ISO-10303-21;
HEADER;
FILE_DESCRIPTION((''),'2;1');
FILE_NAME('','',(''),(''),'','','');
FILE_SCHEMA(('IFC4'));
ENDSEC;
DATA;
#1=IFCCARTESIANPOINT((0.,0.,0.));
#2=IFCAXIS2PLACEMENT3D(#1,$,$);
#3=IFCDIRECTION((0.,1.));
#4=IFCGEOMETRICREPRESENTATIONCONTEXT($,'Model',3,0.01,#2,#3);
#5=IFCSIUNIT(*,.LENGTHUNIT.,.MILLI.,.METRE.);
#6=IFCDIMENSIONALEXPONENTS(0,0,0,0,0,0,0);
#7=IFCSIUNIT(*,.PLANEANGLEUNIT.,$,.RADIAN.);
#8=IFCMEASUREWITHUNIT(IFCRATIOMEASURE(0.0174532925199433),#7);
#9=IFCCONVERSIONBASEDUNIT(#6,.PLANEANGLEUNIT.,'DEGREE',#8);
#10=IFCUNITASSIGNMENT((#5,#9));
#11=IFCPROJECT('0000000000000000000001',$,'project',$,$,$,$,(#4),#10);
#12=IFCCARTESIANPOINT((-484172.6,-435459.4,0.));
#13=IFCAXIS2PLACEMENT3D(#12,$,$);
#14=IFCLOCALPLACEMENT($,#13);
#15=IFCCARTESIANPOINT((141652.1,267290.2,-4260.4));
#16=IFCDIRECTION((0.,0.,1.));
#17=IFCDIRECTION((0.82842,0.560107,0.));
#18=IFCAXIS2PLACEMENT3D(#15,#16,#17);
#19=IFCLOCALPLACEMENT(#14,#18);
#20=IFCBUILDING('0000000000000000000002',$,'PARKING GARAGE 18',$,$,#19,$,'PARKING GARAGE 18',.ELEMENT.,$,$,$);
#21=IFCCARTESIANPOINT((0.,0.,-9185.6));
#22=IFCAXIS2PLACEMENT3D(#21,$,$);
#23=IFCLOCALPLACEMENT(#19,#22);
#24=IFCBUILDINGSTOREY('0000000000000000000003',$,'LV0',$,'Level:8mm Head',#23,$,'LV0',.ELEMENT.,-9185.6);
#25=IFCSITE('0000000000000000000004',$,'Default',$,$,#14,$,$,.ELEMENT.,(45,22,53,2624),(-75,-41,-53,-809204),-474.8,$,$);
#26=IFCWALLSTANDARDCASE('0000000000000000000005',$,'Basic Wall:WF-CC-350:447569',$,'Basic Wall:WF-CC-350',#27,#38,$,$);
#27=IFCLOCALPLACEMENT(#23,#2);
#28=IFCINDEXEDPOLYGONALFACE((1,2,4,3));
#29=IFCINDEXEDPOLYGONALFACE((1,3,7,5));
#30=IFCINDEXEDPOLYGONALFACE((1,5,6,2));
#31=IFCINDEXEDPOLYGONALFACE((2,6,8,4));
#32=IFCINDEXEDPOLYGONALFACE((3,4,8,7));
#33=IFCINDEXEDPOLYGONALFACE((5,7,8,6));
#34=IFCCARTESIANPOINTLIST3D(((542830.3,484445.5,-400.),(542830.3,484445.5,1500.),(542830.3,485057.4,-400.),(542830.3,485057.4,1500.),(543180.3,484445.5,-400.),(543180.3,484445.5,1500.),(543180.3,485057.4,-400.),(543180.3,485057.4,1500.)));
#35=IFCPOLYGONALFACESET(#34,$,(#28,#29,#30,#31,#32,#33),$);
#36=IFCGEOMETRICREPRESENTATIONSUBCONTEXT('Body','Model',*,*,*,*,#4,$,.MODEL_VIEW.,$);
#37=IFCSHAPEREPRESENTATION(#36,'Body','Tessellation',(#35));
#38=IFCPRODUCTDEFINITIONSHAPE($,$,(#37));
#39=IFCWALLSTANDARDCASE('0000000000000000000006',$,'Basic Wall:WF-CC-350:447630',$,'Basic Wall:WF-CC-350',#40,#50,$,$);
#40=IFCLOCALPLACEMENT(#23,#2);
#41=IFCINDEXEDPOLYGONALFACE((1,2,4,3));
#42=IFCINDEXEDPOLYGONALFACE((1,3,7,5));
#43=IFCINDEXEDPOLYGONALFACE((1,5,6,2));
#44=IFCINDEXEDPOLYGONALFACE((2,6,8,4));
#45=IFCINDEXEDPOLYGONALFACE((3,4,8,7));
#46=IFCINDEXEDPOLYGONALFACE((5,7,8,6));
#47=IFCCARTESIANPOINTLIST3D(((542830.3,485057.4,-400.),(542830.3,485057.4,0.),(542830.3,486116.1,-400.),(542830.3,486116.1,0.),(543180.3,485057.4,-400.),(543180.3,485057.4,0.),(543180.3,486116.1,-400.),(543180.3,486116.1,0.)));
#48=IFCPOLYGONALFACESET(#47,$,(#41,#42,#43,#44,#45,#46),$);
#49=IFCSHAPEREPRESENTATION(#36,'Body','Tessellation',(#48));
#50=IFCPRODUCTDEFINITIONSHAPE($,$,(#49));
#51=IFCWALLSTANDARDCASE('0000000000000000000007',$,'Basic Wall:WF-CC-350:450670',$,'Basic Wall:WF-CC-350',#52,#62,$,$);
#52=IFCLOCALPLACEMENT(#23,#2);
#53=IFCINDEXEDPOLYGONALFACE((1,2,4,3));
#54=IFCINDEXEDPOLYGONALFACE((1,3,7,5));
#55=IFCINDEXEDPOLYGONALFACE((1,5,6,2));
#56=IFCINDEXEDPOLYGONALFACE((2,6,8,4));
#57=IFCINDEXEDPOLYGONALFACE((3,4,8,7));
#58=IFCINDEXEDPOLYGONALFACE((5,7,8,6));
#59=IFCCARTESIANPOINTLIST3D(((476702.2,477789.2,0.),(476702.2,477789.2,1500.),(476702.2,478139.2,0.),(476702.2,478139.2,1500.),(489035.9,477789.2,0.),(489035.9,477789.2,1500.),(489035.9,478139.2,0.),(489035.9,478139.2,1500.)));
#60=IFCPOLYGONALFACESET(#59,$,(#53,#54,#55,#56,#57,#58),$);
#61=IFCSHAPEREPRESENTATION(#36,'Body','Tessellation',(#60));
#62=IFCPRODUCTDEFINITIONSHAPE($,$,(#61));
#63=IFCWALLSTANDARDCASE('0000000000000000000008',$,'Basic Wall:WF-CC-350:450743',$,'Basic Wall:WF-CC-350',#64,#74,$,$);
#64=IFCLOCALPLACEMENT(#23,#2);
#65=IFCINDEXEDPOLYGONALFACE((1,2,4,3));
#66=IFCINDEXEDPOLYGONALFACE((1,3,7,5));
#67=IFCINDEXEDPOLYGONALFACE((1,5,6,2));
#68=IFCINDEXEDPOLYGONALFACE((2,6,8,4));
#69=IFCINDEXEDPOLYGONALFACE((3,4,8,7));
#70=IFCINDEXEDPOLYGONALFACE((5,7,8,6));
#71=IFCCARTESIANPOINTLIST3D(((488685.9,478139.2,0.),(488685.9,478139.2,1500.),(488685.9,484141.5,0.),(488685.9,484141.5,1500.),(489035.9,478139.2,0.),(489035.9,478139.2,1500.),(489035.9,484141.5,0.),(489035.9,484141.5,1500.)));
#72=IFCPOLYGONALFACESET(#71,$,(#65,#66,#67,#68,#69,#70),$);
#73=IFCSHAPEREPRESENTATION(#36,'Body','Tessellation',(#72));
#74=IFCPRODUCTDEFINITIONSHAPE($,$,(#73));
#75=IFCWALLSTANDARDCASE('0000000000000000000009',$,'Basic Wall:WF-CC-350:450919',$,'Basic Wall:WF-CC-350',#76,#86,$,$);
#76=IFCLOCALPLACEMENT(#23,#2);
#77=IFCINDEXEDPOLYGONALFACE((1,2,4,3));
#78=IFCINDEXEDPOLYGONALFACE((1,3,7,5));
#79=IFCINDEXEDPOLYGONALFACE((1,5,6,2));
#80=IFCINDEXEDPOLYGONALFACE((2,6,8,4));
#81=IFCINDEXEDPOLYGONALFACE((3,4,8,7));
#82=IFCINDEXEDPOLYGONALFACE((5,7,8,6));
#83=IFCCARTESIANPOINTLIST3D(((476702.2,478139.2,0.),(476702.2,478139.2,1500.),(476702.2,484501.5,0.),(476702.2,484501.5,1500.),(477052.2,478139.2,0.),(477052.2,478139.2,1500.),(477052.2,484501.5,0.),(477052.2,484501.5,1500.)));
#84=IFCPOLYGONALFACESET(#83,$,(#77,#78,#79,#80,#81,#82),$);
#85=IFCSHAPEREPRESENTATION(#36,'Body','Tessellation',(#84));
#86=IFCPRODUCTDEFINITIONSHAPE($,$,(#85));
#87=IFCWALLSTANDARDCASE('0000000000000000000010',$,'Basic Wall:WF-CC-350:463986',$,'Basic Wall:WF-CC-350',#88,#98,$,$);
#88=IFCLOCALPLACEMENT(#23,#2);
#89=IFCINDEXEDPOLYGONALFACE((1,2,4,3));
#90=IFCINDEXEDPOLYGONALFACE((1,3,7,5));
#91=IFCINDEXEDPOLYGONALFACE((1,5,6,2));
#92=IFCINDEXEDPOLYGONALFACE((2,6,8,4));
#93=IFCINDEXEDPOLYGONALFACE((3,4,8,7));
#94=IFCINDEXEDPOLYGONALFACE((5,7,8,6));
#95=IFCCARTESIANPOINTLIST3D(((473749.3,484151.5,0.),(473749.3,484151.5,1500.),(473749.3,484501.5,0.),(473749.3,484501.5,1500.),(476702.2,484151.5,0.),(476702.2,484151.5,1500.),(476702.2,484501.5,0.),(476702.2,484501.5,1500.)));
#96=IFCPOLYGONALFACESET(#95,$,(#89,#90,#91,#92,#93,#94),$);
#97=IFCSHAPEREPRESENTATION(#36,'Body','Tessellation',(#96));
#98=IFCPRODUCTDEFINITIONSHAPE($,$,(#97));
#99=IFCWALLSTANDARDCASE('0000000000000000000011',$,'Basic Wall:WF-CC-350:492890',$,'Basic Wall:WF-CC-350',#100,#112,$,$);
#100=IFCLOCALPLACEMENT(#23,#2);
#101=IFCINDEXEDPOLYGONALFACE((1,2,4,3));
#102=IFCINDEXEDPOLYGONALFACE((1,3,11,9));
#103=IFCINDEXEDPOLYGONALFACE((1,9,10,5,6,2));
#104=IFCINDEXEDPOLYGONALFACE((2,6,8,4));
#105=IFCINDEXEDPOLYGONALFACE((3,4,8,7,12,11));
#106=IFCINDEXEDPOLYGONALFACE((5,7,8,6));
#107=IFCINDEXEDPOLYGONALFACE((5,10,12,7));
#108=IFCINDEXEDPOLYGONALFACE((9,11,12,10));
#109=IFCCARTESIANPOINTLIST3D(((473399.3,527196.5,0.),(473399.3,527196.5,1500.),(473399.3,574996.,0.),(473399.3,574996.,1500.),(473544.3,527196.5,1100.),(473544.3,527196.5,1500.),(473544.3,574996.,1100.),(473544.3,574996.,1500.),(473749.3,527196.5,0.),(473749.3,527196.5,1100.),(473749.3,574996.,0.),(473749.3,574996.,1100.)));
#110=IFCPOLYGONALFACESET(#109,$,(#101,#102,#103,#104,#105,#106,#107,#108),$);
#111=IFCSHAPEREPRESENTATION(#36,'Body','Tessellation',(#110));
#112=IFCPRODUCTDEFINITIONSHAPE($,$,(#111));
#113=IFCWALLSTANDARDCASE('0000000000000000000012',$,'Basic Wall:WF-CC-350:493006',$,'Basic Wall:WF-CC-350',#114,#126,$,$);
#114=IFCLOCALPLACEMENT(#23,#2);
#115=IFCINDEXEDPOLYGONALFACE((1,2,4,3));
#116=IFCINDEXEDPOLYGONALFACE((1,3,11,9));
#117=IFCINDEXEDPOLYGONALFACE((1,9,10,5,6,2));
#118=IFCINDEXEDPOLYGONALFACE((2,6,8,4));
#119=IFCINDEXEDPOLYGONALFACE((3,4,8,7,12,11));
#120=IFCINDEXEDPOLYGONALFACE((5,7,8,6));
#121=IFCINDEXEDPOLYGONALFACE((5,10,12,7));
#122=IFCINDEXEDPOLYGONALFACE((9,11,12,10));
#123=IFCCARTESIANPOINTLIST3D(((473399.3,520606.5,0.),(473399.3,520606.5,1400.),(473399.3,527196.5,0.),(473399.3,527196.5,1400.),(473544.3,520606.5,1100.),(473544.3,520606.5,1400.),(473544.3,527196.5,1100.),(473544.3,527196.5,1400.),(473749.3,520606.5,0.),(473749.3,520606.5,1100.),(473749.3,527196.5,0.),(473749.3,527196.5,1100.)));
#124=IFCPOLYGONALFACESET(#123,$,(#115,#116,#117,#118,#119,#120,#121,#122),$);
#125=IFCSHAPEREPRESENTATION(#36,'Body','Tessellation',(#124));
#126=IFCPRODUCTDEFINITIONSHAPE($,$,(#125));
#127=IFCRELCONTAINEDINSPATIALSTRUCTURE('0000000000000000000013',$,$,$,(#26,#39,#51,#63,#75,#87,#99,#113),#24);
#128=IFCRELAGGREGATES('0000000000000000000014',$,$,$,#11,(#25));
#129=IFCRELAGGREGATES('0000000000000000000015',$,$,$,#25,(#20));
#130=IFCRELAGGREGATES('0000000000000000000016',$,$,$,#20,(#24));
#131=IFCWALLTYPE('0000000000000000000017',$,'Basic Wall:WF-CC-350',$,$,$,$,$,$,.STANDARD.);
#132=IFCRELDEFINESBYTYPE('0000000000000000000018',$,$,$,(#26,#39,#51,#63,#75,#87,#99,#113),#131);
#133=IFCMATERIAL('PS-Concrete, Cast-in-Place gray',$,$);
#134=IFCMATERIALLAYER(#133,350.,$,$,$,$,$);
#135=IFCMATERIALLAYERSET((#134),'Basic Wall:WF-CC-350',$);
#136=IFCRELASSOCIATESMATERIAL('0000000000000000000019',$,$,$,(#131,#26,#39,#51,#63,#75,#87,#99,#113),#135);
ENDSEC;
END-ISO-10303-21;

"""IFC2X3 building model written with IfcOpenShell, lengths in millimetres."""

from ifc_helpers import new_model, entity, si_unit, converted_unit, direction, frame, frame_2d, origin, place, context, subcontext, project, spatial, polyline, rectangle, extrude, clip, bounded_halfspace, material, layer, layer_set, layer_usage, type_object, element, save


model = new_model("IFC2X3")

# Units and contexts
model_context = context("Model", 3, precision=0.01, world=origin(), true_north=direction((0.0, 1.0)))
body_context = subcontext(model_context, "Body", "Model", "MODEL_VIEW")
ifc_project = project(units=[si_unit("LENGTHUNIT", "METRE", prefix="MILLI"), converted_unit("PLANEANGLEUNIT", "DEGREE", entity("IfcRatioMeasure", 0.0174532925199433), si_unit("PLANEANGLEUNIT", "RADIAN"), dimensions=[0, 0, 0, 0, 0, 0, 0])], contexts=[model_context])

# Site, building, storey
site_placement = place(None, frame((-484172.6, -435459.4, 0.0)))
site = spatial("IfcSite", under=ifc_project, at=site_placement, Name="Default", CompositionType="ELEMENT", RefLatitude=(45, 22, 53, 2624), RefLongitude=(-75, -41, -53, -809204), RefElevation=-474.8)
building_placement = place(site_placement, frame((141652.1, 267290.2, -4260.4), z_axis=(0.0, 0.0, 1.0), x_axis=(0.82842, 0.560107, 0.0)))
building = spatial("IfcBuilding", under=site, at=building_placement, Name="PARKING GARAGE 18", LongName="PARKING GARAGE 18", CompositionType="ELEMENT")
storey_placement = place(building_placement, frame((0.0, 0.0, -9185.6)))
storey = spatial("IfcBuildingStorey", under=building, at=storey_placement, Name="LV0", ObjectType="Level:8mm Head", LongName="LV0", CompositionType="ELEMENT", Elevation=-9185.6)

# Walls
ifc_material_1 = material(Name="PS-Concrete, Cast-in-Place gray")
ifc_layer_1 = layer(ifc_material_1, 350.0)
ifc_layer_set_1 = layer_set([ifc_layer_1], Name="Basic Wall:WF-CC-350")
wall_type_1 = type_object("IfcWallType", Name="Basic Wall:WF-CC-350", PredefinedType="STANDARD", material=ifc_layer_set_1)
ifc_layer_usage_1 = layer_usage(ifc_layer_set_1, "AXIS2", "POSITIVE", -175.0)
wall_1_placement = place(storey_placement, frame((543005.3, 484445.5, -400.0), z_axis=(0.0, 0.0, 1.0), x_axis=(0.0, 1.0, 0.0)))
element("IfcWallStandardCase", 1, at=wall_1_placement, inside=storey, type_object=wall_type_1, material=ifc_layer_usage_1, Name="Basic Wall:WF-CC-350:447569", ObjectType="Basic Wall:WF-CC-350", context=body_context, shape_type="SweptSolid", body=[
    extrude(rectangle(XDim=611.9, YDim=350.0, at=frame_2d((305.9, 0.0), x_axis=(-1.0, 0.0))), origin(), (0.0, 0.0, 1.0), 1900.0),
])
ifc_layer_usage_2 = layer_usage(ifc_layer_set_1, "AXIS2", "POSITIVE", -175.0)
wall_2_placement = place(storey_placement, frame((543005.3, 485057.4, -400.0), z_axis=(0.0, 0.0, 1.0), x_axis=(0.0, 1.0, 0.0)))
element("IfcWallStandardCase", 2, at=wall_2_placement, inside=storey, type_object=wall_type_1, material=ifc_layer_usage_2, Name="Basic Wall:WF-CC-350:447630", ObjectType="Basic Wall:WF-CC-350", context=body_context, shape_type="SweptSolid", body=[
    extrude(rectangle(XDim=1058.7, YDim=350.0, at=frame_2d((529.3, 0.0), x_axis=(-1.0, 0.0))), origin(), (0.0, 0.0, 1.0), 400.0),
])
ifc_layer_usage_3 = layer_usage(ifc_layer_set_1, "AXIS2", "NEGATIVE", 175.0)
wall_3_placement = place(storey_placement, frame((489035.9, 477964.2, 0.0), z_axis=(0.0, 0.0, 1.0), x_axis=(-1.0, 0.0, 0.0)))
element("IfcWallStandardCase", 3, at=wall_3_placement, inside=storey, type_object=wall_type_1, material=ifc_layer_usage_3, Name="Basic Wall:WF-CC-350:450670", ObjectType="Basic Wall:WF-CC-350", context=body_context, shape_type="SweptSolid", body=[
    extrude(rectangle(XDim=12333.7, YDim=350.0, at=frame_2d((6166.8, 0.0), x_axis=(-1.0, 0.0))), origin(), (0.0, 0.0, 1.0), 1500.0),
])
ifc_layer_usage_4 = layer_usage(ifc_layer_set_1, "AXIS2", "POSITIVE", -175.0)
wall_4_placement = place(storey_placement, frame((488860.9, 478139.2, 0.0), z_axis=(0.0, 0.0, 1.0), x_axis=(0.0, 1.0, 0.0)))
element("IfcWallStandardCase", 4, at=wall_4_placement, inside=storey, type_object=wall_type_1, material=ifc_layer_usage_4, Name="Basic Wall:WF-CC-350:450743", ObjectType="Basic Wall:WF-CC-350", context=body_context, shape_type="SweptSolid", body=[
    extrude(rectangle(XDim=6002.3, YDim=350.0, at=frame_2d((3001.1, 0.0), x_axis=(-1.0, 0.0))), origin(), (0.0, 0.0, 1.0), 1500.0),
])
ifc_layer_usage_5 = layer_usage(ifc_layer_set_1, "AXIS2", "NEGATIVE", 175.0)
wall_5_placement = place(storey_placement, frame((476877.2, 478139.2, 0.0), z_axis=(0.0, 0.0, 1.0), x_axis=(0.0, 1.0, 0.0)))
element("IfcWallStandardCase", 5, at=wall_5_placement, inside=storey, type_object=wall_type_1, material=ifc_layer_usage_5, Name="Basic Wall:WF-CC-350:450919", ObjectType="Basic Wall:WF-CC-350", context=body_context, shape_type="SweptSolid", body=[
    extrude(rectangle(XDim=6362.3, YDim=350.0, at=frame_2d((3181.1, 0.0), x_axis=(-1.0, 0.0))), origin(), (0.0, 0.0, 1.0), 1500.0),
])
ifc_layer_usage_6 = layer_usage(ifc_layer_set_1, "AXIS2", "NEGATIVE", 175.0)
wall_6_placement = place(storey_placement, frame((476702.2, 484326.5, 0.0), z_axis=(0.0, 0.0, 1.0), x_axis=(-1.0, 0.0, 0.0)))
element("IfcWallStandardCase", 6, at=wall_6_placement, inside=storey, type_object=wall_type_1, material=ifc_layer_usage_6, Name="Basic Wall:WF-CC-350:463986", ObjectType="Basic Wall:WF-CC-350", context=body_context, shape_type="SweptSolid", body=[
    extrude(rectangle(XDim=2952.9, YDim=350.0, at=frame_2d((1476.5, 0.0), x_axis=(-1.0, 0.0))), origin(), (0.0, 0.0, 1.0), 1500.0),
])
ifc_layer_usage_7 = layer_usage(ifc_layer_set_1, "AXIS2", "NEGATIVE", 175.0)
wall_7_placement = place(storey_placement, frame((473574.3, 527196.5, 0.0), z_axis=(0.0, 0.0, 1.0), x_axis=(0.0, 1.0, 0.0)))
element("IfcWallStandardCase", 7, at=wall_7_placement, inside=storey, type_object=wall_type_1, material=ifc_layer_usage_7, Name="Basic Wall:WF-CC-350:492890", ObjectType="Basic Wall:WF-CC-350", context=body_context, shape_type="Clipping", body=[
    clip(clip(extrude(rectangle(XDim=47799.5, YDim=350.0, at=frame_2d((23899.7, 0.0), x_axis=(-1.0, 0.0))), origin(), (0.0, 0.0, 1.0), 1500.0), bounded_halfspace(frame((47799.5, 30.0, 1100.0), z_axis=(0.0, 0.0, -1.0), x_axis=(-1.0, 0.0, 0.0)), True, frame((47799.5, 30.0, 1100.0), z_axis=(0.0, 0.0, -1.0), x_axis=(-1.0, 0.0, 0.0)), polyline([(0.0, 0.0), (0.0, -205.0), (47799.5, -205.0), (47799.5, 0.0), (0.0, 0.0)]))), bounded_halfspace(frame((0.0, 30.0, 1100.0), z_axis=(0.0, 1.0, 0.0), x_axis=(0.0, 0.0, 1.0)), True, frame((0.0, 30.0, 1100.0), z_axis=(0.0, 1.0, 0.0), x_axis=(0.0, 0.0, 1.0)), polyline([(0.0, 0.0), (300.0, 0.0), (400.0, 0.0), (400.0, 47799.5), (0.0, 47799.5), (0.0, 0.0)]))),
])
ifc_layer_usage_8 = layer_usage(ifc_layer_set_1, "AXIS2", "NEGATIVE", 175.0)
wall_8_placement = place(storey_placement, frame((473574.3, 520606.5, 0.0), z_axis=(0.0, 0.0, 1.0), x_axis=(0.0, 1.0, 0.0)))
element("IfcWallStandardCase", 8, at=wall_8_placement, inside=storey, type_object=wall_type_1, material=ifc_layer_usage_8, Name="Basic Wall:WF-CC-350:493006", ObjectType="Basic Wall:WF-CC-350", context=body_context, shape_type="Clipping", body=[
    clip(clip(extrude(rectangle(XDim=6590.0, YDim=350.0, at=frame_2d((3295.0, 0.0), x_axis=(-1.0, 0.0))), origin(), (0.0, 0.0, 1.0), 1400.0), bounded_halfspace(frame((6590.0, 30.0, 1100.0), z_axis=(0.0, 0.0, -1.0), x_axis=(-1.0, 0.0, 0.0)), True, frame((6590.0, 30.0, 1100.0), z_axis=(0.0, 0.0, -1.0), x_axis=(-1.0, 0.0, 0.0)), polyline([(0.0, 0.0), (0.0, -205.0), (6590.0, -205.0), (6590.0, 0.0), (0.0, 0.0)]))), bounded_halfspace(frame((0.0, 30.0, 1100.0), z_axis=(0.0, 1.0, 0.0), x_axis=(0.0, 0.0, 1.0)), True, frame((0.0, 30.0, 1100.0), z_axis=(0.0, 1.0, 0.0), x_axis=(0.0, 0.0, 1.0)), polyline([(0.0, 0.0), (300.0, 0.0), (300.0, 6590.0), (0.0, 6590.0), (0.0, 0.0)]))),
])

save(model, "model.ifc")
